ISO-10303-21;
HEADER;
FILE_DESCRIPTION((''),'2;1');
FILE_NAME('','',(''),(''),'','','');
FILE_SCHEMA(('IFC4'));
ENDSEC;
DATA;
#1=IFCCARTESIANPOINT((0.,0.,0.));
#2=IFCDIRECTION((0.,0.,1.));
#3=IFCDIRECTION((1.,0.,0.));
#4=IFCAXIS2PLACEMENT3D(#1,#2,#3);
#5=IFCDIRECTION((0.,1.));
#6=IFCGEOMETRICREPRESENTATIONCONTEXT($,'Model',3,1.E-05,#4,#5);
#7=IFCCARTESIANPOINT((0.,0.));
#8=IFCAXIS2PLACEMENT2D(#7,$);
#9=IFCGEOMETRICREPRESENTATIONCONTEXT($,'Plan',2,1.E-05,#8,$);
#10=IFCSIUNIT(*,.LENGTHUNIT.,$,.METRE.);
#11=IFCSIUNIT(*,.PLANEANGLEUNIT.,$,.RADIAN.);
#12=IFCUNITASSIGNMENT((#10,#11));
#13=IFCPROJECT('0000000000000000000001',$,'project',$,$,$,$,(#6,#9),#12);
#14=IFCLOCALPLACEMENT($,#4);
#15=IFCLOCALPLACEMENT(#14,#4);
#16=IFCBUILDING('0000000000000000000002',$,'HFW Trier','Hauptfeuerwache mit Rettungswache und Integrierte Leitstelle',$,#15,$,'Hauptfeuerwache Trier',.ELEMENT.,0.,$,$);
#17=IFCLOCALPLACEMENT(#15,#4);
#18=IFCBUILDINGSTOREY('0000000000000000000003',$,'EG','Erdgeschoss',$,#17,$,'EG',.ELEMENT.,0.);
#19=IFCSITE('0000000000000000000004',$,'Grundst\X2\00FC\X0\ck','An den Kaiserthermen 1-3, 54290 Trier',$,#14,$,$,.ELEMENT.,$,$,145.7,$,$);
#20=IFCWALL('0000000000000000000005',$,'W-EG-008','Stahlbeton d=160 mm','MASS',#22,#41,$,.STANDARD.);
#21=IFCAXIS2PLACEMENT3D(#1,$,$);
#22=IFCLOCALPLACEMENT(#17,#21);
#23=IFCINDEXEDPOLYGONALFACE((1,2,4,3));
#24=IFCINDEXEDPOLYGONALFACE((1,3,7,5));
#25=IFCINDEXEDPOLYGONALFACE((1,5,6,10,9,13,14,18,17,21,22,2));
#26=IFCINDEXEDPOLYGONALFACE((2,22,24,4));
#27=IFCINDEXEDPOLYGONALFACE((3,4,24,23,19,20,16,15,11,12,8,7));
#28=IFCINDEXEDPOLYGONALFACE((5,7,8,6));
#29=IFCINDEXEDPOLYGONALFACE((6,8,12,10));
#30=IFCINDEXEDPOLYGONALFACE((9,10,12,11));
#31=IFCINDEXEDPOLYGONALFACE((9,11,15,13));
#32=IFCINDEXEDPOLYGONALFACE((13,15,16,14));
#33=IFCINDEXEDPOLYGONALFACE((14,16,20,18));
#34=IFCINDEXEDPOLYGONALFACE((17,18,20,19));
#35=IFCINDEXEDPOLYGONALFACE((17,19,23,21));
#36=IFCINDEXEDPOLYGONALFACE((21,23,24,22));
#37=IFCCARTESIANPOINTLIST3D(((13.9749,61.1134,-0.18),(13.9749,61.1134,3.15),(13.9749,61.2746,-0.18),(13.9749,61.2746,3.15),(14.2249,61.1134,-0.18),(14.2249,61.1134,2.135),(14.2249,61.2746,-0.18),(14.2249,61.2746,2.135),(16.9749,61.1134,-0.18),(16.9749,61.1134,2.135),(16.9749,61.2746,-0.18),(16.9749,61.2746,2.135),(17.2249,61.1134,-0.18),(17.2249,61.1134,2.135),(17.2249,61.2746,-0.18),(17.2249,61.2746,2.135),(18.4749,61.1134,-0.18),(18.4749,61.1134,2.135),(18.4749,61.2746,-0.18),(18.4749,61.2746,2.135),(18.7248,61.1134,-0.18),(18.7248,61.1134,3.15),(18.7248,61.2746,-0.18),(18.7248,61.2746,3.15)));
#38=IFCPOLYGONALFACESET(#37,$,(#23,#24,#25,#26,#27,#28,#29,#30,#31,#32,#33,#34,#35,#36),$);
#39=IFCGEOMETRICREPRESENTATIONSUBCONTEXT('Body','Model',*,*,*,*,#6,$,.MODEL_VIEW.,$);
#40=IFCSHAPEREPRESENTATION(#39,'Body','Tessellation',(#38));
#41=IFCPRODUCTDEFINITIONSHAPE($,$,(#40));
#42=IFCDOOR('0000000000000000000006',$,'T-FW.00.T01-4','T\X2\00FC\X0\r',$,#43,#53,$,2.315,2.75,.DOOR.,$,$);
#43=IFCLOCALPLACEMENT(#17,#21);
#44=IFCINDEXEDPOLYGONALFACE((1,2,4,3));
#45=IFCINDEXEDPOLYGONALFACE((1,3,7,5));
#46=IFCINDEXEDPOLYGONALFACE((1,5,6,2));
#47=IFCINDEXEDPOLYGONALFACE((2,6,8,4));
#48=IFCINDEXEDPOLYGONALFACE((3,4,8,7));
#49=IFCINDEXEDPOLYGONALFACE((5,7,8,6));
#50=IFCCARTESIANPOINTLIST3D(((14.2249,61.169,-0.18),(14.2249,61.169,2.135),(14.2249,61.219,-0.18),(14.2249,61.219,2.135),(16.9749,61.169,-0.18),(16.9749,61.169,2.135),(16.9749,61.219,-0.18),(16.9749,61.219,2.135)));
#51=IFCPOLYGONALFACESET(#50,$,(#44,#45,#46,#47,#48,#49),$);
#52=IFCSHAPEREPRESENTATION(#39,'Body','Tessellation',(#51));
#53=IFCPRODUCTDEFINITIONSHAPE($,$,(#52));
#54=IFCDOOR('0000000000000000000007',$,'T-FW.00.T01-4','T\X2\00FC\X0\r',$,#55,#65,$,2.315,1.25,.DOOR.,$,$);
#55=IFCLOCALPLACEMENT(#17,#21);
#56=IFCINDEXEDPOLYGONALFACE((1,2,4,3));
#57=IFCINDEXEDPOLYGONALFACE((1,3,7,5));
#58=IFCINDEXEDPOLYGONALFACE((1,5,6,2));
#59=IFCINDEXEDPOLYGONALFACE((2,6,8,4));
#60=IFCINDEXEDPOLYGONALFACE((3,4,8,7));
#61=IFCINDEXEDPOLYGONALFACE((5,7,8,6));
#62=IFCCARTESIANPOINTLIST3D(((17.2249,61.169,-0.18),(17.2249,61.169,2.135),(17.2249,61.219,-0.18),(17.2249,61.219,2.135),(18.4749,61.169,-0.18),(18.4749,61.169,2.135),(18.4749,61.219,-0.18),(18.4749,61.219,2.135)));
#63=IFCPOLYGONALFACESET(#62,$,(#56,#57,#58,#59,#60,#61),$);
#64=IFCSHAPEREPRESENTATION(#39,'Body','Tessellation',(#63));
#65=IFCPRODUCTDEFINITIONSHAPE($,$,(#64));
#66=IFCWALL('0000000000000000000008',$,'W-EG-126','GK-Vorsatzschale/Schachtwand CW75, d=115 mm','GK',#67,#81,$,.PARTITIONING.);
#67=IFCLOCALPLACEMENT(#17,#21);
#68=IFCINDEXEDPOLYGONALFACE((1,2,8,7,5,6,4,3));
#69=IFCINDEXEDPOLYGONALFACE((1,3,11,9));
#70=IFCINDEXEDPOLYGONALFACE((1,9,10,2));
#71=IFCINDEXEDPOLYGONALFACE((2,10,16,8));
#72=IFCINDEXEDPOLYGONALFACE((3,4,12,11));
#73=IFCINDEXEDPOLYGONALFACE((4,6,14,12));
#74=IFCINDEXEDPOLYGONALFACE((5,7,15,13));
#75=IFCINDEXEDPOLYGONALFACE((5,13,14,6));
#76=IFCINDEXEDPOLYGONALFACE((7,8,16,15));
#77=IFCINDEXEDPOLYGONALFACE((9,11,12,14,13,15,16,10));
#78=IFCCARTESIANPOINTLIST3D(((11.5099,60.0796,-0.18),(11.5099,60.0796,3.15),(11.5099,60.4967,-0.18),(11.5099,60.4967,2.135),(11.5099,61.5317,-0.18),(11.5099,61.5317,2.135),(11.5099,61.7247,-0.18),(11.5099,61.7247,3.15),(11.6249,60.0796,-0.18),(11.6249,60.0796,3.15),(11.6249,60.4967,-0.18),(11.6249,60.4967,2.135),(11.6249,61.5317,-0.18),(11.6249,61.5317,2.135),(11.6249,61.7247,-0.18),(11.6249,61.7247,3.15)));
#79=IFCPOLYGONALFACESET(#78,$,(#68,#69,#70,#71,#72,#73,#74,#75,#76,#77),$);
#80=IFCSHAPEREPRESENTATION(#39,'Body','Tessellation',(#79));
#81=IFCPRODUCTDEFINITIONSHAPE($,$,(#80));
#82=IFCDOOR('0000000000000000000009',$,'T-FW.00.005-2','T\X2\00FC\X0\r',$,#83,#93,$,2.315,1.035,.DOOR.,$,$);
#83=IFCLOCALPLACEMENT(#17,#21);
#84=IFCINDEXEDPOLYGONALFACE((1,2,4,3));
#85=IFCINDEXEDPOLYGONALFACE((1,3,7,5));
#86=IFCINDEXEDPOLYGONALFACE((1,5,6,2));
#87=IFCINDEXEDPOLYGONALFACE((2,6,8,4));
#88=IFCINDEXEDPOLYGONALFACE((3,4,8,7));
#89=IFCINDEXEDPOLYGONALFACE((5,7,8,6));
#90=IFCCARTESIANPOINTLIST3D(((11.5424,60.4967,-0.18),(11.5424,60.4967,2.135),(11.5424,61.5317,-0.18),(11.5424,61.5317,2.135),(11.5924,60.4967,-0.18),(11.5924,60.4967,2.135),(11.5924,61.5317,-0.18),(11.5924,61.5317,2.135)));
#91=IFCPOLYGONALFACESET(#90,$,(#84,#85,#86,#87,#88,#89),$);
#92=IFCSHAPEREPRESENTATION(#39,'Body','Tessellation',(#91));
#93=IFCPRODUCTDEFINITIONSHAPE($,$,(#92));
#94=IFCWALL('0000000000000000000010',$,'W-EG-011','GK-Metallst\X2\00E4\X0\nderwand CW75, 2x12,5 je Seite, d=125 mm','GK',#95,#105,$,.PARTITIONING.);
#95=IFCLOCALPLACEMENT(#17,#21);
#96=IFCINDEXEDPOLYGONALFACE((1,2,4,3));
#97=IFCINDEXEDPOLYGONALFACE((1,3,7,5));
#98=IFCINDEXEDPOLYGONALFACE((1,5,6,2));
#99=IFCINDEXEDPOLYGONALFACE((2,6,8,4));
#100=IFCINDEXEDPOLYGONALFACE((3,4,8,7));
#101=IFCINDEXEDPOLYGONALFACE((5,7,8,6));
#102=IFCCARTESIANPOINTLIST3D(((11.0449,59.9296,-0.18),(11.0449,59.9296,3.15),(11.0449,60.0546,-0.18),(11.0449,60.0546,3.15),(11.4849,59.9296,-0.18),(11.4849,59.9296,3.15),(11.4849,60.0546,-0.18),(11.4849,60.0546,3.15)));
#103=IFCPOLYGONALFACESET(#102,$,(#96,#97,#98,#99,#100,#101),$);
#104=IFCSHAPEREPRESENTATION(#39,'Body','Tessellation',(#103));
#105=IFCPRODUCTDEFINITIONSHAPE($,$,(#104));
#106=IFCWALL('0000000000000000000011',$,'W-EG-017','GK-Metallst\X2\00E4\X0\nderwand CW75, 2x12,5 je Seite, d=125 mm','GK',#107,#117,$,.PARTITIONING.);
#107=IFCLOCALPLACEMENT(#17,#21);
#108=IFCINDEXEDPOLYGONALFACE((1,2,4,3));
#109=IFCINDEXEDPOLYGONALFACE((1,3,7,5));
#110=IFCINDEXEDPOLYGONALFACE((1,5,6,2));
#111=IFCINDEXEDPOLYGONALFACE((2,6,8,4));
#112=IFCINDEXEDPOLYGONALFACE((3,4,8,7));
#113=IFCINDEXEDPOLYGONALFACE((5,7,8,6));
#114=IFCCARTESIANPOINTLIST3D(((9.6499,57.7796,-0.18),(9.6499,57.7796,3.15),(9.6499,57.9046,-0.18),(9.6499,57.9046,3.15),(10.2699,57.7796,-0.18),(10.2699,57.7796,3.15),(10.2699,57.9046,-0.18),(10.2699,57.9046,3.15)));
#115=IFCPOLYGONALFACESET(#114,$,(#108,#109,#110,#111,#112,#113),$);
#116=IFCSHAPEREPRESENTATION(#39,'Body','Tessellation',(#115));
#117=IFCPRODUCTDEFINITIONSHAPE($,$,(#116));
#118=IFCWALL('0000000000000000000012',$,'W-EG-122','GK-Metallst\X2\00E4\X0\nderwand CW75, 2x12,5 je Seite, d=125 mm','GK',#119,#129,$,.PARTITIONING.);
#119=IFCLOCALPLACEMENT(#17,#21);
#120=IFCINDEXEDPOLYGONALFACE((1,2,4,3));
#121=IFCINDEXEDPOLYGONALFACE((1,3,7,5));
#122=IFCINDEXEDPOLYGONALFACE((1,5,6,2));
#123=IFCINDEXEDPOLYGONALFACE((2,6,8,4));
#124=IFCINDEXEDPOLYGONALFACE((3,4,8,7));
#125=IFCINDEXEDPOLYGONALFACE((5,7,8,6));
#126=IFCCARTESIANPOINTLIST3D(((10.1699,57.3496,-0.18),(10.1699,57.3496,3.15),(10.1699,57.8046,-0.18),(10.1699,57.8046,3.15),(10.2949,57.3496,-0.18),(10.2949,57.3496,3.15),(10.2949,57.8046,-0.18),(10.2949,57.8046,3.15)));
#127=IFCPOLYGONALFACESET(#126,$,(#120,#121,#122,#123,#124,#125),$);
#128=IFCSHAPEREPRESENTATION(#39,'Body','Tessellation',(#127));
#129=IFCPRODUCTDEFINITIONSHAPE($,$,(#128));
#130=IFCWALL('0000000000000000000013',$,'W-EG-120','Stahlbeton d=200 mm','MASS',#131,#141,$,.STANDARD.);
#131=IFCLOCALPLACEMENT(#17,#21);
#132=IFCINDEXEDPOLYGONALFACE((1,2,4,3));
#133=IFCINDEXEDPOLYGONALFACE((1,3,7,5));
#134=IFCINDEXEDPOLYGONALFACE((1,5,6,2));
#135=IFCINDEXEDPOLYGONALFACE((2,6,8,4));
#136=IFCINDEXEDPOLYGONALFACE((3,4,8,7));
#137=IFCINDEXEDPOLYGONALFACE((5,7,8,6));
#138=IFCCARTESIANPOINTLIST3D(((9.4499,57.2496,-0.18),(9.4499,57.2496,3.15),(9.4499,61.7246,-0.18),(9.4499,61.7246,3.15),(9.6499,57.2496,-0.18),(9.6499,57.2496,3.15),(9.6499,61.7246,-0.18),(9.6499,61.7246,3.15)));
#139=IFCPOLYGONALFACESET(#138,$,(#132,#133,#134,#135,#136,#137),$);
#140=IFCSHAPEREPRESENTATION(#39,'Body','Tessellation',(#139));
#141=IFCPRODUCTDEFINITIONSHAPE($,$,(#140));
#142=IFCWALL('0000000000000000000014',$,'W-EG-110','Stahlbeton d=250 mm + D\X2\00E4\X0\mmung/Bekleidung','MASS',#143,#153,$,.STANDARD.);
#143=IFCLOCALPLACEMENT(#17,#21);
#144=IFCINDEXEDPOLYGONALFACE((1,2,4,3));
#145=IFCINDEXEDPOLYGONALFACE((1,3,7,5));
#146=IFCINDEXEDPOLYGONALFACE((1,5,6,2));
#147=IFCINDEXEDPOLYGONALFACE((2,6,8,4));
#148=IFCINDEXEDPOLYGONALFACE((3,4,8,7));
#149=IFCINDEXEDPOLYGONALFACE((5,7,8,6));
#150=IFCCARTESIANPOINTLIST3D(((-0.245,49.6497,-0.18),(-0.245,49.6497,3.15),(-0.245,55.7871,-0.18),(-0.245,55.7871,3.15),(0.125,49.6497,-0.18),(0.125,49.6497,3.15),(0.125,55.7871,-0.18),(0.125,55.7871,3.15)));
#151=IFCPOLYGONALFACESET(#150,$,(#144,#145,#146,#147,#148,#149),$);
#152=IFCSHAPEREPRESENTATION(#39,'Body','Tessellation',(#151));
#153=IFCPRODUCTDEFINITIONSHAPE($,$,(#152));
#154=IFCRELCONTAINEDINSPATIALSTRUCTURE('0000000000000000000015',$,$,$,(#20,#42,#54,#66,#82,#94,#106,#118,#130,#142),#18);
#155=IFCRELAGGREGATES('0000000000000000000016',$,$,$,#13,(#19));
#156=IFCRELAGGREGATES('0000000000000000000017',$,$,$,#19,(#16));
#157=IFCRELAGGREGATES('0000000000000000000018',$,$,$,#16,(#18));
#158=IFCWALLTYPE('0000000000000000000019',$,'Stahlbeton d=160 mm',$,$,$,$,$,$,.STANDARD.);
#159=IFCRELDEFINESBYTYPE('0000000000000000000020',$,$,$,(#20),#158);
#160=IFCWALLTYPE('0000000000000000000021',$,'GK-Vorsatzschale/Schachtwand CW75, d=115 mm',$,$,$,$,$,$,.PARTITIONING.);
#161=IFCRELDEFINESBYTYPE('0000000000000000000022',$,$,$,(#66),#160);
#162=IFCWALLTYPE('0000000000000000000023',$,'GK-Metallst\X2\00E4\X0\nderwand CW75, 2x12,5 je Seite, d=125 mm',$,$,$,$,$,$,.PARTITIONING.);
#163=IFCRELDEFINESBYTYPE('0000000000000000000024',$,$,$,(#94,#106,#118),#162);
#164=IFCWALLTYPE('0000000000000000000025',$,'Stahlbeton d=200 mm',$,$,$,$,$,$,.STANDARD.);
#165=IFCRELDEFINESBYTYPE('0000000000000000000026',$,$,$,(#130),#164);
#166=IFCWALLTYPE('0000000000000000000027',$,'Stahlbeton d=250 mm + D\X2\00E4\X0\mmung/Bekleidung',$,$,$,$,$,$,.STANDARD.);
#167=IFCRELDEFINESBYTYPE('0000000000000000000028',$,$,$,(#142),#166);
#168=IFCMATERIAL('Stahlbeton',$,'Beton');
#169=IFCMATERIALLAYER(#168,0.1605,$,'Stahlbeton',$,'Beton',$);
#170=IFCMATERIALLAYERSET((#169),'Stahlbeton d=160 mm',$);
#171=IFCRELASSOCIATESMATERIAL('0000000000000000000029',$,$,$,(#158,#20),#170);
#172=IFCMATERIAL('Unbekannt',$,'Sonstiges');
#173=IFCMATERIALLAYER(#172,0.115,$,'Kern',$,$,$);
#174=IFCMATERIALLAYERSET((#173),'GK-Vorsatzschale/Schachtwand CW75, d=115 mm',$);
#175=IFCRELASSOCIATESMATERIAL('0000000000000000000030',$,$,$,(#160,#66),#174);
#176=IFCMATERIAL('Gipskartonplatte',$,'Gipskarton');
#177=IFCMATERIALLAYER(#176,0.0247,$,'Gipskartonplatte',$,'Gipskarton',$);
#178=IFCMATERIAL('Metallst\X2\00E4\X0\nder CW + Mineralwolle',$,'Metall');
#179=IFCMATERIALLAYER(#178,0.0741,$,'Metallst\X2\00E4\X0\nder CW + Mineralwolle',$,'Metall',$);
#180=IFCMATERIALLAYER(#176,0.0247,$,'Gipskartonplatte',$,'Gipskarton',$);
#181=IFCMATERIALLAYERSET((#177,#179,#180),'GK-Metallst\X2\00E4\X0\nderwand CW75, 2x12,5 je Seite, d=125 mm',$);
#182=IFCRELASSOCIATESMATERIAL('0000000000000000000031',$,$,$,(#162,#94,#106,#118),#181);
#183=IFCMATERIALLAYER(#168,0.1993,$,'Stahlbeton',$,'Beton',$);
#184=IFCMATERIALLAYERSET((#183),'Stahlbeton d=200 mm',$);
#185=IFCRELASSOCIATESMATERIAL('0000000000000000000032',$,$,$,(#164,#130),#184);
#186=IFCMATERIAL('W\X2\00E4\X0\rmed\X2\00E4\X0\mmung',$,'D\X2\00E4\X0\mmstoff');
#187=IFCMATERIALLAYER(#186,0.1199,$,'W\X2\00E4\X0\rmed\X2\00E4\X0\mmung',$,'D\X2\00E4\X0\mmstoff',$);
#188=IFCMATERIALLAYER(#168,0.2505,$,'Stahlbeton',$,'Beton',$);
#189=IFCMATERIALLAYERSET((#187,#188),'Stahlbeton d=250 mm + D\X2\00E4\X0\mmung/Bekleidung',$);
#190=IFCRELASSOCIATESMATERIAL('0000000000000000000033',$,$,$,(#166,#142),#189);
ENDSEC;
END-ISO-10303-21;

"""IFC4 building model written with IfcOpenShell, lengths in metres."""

from ifc_helpers import new_model, si_unit, direction, frame, frame_2d, origin_with_axes, origin_2d, place, context, subcontext, project, spatial, rectangle, extrude, material, layer, layer_set, layer_usage, type_object, element, fill, save


model = new_model("IFC4")

# Units and contexts
model_context = context("Model", 3, precision=1e-05, world=origin_with_axes(), true_north=direction((0.0, 1.0)))
plan_context = context("Plan", 2, precision=1e-05, world=origin_2d())
body_context = subcontext(model_context, "Body", "Model", "MODEL_VIEW")
ifc_project = project(units=[si_unit("LENGTHUNIT", "METRE"), si_unit("PLANEANGLEUNIT", "RADIAN")], contexts=[model_context, plan_context])

# Site, building, storey
site_placement = place(None, origin_with_axes())
site = spatial("IfcSite", under=ifc_project, at=site_placement, Name="Grundstück", Description="An den Kaiserthermen 1-3, 54290 Trier", CompositionType="ELEMENT", RefElevation=145.7)
building_placement = place(site_placement, origin_with_axes())
building = spatial("IfcBuilding", under=site, at=building_placement, Name="HFW Trier", Description="Hauptfeuerwache mit Rettungswache und Integrierte Leitstelle", LongName="Hauptfeuerwache Trier", CompositionType="ELEMENT", ElevationOfRefHeight=0.0)
storey_placement = place(building_placement, origin_with_axes())
storey = spatial("IfcBuildingStorey", under=building, at=storey_placement, Name="EG", Description="Erdgeschoss", LongName="EG", CompositionType="ELEMENT", Elevation=0.0)

# Shared definitions
ifc_material_1 = material(Name="Stahlbeton", Category="Beton")

# Shared definitions
ifc_material_2 = material(Name="Gipskartonplatte", Category="Gipskarton")
ifc_material_3 = material(Name="Metallständer CW + Mineralwolle", Category="Metall")

# Wall, openings, doors
ifc_layer_1 = layer(ifc_material_1, 0.1605, Name="Stahlbeton", Category="Beton")
ifc_layer_set_1 = layer_set([ifc_layer_1], Name="Stahlbeton d=160 mm")
ifc_layer_usage_1 = layer_usage(ifc_layer_set_1, "AXIS2", "POSITIVE", -0.0805)
wall_type_1 = type_object("IfcWallType", Name="Stahlbeton d=160 mm", PredefinedType="STANDARD", material=ifc_layer_set_1)
wall_1_placement = place(storey_placement, frame((13.9749, 61.194, -0.18), z_axis=(0.0, 0.0, 1.0), x_axis=(1.0, 0.0, 0.0)))
wall_1 = element("IfcWall", 1, at=wall_1_placement, inside=storey, type_object=wall_type_1, material=ifc_layer_usage_1, Name="W-EG-008", Description="Stahlbeton d=160 mm", ObjectType="MASS", PredefinedType="STANDARD", context=body_context, shape_type="SweptSolid", body=[
    extrude(rectangle(XDim=4.7499, YDim=0.1611, at=frame_2d((2.3749, 0.0))), origin_with_axes(), (0.0, 0.0, 1.0), 3.33),
])
opening_1_placement = place(wall_1_placement, frame((0.25, 0.0, 0.0), z_axis=(0.0, 0.0, 1.0), x_axis=(1.0, 0.0, 0.0)))
opening_1 = element("IfcOpeningElement", 2, at=opening_1_placement, cuts=wall_1, PredefinedType="OPENING", context=body_context, shape_type="SweptSolid", body=[
    extrude(rectangle(XDim=2.75, YDim=0.2611, at=frame_2d((1.375, 0.0))), origin_with_axes(), (0.0, 0.0, 1.0), 2.315),
])
opening_2_placement = place(wall_1_placement, frame((3.25, 0.0, 0.0), z_axis=(0.0, 0.0, 1.0), x_axis=(1.0, 0.0, 0.0)))
opening_2 = element("IfcOpeningElement", 3, at=opening_2_placement, cuts=wall_1, PredefinedType="OPENING", context=body_context, shape_type="SweptSolid", body=[
    extrude(rectangle(XDim=1.25, YDim=0.2611, at=frame_2d((0.625, 0.0))), origin_with_axes(), (0.0, 0.0, 1.0), 2.315),
])
door_1_placement = place(wall_1_placement, frame((0.25, 0.0, 0.0), z_axis=(0.0, 0.0, 1.0), x_axis=(1.0, 0.0, 0.0)))
door_1 = element("IfcDoor", 4, at=door_1_placement, inside=storey, Name="T-FW.00.T01-4", Description="Tür", OverallHeight=2.315, OverallWidth=2.75, PredefinedType="DOOR", context=body_context, shape_type="SweptSolid", body=[
    extrude(rectangle(XDim=2.75, YDim=0.05, at=frame_2d((1.375, 0.0))), origin_with_axes(), (0.0, 0.0, 1.0), 2.315),
])
fill(opening_1, door_1)
door_2_placement = place(wall_1_placement, frame((3.25, 0.0, 0.0), z_axis=(0.0, 0.0, 1.0), x_axis=(1.0, 0.0, 0.0)))
door_2 = element("IfcDoor", 5, at=door_2_placement, inside=storey, Name="T-FW.00.T01-4", Description="Tür", OverallHeight=2.315, OverallWidth=1.25, PredefinedType="DOOR", context=body_context, shape_type="SweptSolid", body=[
    extrude(rectangle(XDim=1.25, YDim=0.05, at=frame_2d((0.625, 0.0))), origin_with_axes(), (0.0, 0.0, 1.0), 2.315),
])
fill(opening_2, door_2)

# Wall, opening, door
ifc_material_4 = material(Name="Unbekannt", Category="Sonstiges")
ifc_layer_2 = layer(ifc_material_4, 0.115, Name="Kern")
ifc_layer_set_2 = layer_set([ifc_layer_2], Name="GK-Vorsatzschale/Schachtwand CW75, d=115 mm")
ifc_layer_usage_2 = layer_usage(ifc_layer_set_2, "AXIS2", "POSITIVE", -0.0575)
wall_type_2 = type_object("IfcWallType", Name="GK-Vorsatzschale/Schachtwand CW75, d=115 mm", PredefinedType="PARTITIONING", material=ifc_layer_set_2)
wall_2_placement = place(storey_placement, frame((11.5674, 61.7247, -0.18), z_axis=(0.0, 0.0, 1.0), x_axis=(0.0, -1.0, 0.0)))
wall_2 = element("IfcWall", 6, at=wall_2_placement, inside=storey, type_object=wall_type_2, material=ifc_layer_usage_2, Name="W-EG-126", Description="GK-Vorsatzschale/Schachtwand CW75, d=115 mm", ObjectType="GK", PredefinedType="PARTITIONING", context=body_context, shape_type="SweptSolid", body=[
    extrude(rectangle(XDim=1.6451, YDim=0.115, at=frame_2d((0.8225, 0.0))), origin_with_axes(), (0.0, 0.0, 1.0), 3.33),
])
opening_3_placement = place(wall_2_placement, frame((0.193, 0.0, 0.0), z_axis=(0.0, 0.0, 1.0), x_axis=(1.0, 0.0, 0.0)))
opening_3 = element("IfcOpeningElement", 7, at=opening_3_placement, cuts=wall_2, PredefinedType="OPENING", context=body_context, shape_type="SweptSolid", body=[
    extrude(rectangle(XDim=1.035, YDim=0.215, at=frame_2d((0.5175, 0.0))), origin_with_axes(), (0.0, 0.0, 1.0), 2.315),
])
door_3_placement = place(wall_2_placement, frame((0.193, 0.0, 0.0), z_axis=(0.0, 0.0, 1.0), x_axis=(1.0, 0.0, 0.0)))
door_3 = element("IfcDoor", 8, at=door_3_placement, inside=storey, Name="T-FW.00.005-2", Description="Tür", OverallHeight=2.315, OverallWidth=1.035, PredefinedType="DOOR", context=body_context, shape_type="SweptSolid", body=[
    extrude(rectangle(XDim=1.035, YDim=0.05, at=frame_2d((0.5175, 0.0))), origin_with_axes(), (0.0, 0.0, 1.0), 2.315),
])
fill(opening_3, door_3)

# Walls
ifc_layer_3 = layer(ifc_material_2, 0.0247, Name="Gipskartonplatte", Category="Gipskarton")
ifc_layer_4 = layer(ifc_material_3, 0.0741, Name="Metallständer CW + Mineralwolle", Category="Metall")
ifc_layer_5 = layer(ifc_material_2, 0.0247, Name="Gipskartonplatte", Category="Gipskarton")
ifc_layer_set_3 = layer_set([ifc_layer_3, ifc_layer_4, ifc_layer_5], Name="GK-Metallständerwand CW75, 2x12,5 je Seite, d=125 mm")
ifc_layer_usage_3 = layer_usage(ifc_layer_set_3, "AXIS2", "POSITIVE", -0.0625)
wall_type_3 = type_object("IfcWallType", Name="GK-Metallständerwand CW75, 2x12,5 je Seite, d=125 mm", PredefinedType="PARTITIONING", material=ifc_layer_set_3)
wall_3_placement = place(storey_placement, frame((11.0449, 59.9921, -0.18), z_axis=(0.0, 0.0, 1.0), x_axis=(1.0, 0.0, 0.0)))
element("IfcWall", 9, at=wall_3_placement, inside=storey, type_object=wall_type_3, material=ifc_layer_usage_3, Name="W-EG-011", Description="GK-Metallständerwand CW75, 2x12,5 je Seite, d=125 mm", ObjectType="GK", PredefinedType="PARTITIONING", context=body_context, shape_type="SweptSolid", body=[
    extrude(rectangle(XDim=0.44, YDim=0.125, at=frame_2d((0.22, 0.0))), origin_with_axes(), (0.0, 0.0, 1.0), 3.33),
])
ifc_layer_usage_4 = layer_usage(ifc_layer_set_3, "AXIS2", "POSITIVE", -0.0625)
wall_4_placement = place(storey_placement, frame((9.6499, 57.8421, -0.18), z_axis=(0.0, 0.0, 1.0), x_axis=(1.0, 0.0, 0.0)))
element("IfcWall", 10, at=wall_4_placement, inside=storey, type_object=wall_type_3, material=ifc_layer_usage_4, Name="W-EG-017", Description="GK-Metallständerwand CW75, 2x12,5 je Seite, d=125 mm", ObjectType="GK", PredefinedType="PARTITIONING", context=body_context, shape_type="SweptSolid", body=[
    extrude(rectangle(XDim=0.62, YDim=0.125, at=frame_2d((0.31, 0.0))), origin_with_axes(), (0.0, 0.0, 1.0), 3.33),
])
ifc_layer_usage_5 = layer_usage(ifc_layer_set_3, "AXIS2", "POSITIVE", -0.0625)
wall_5_placement = place(storey_placement, frame((10.2324, 57.8046, -0.18), z_axis=(0.0, 0.0, 1.0), x_axis=(0.0, -1.0, 0.0)))
element("IfcWall", 11, at=wall_5_placement, inside=storey, type_object=wall_type_3, material=ifc_layer_usage_5, Name="W-EG-122", Description="GK-Metallständerwand CW75, 2x12,5 je Seite, d=125 mm", ObjectType="GK", PredefinedType="PARTITIONING", context=body_context, shape_type="SweptSolid", body=[
    extrude(rectangle(XDim=0.455, YDim=0.125, at=frame_2d((0.2275, 0.0))), origin_with_axes(), (0.0, 0.0, 1.0), 3.33),
])
ifc_layer_6 = layer(ifc_material_1, 0.1993, Name="Stahlbeton", Category="Beton")
ifc_layer_set_4 = layer_set([ifc_layer_6], Name="Stahlbeton d=200 mm")
ifc_layer_usage_6 = layer_usage(ifc_layer_set_4, "AXIS2", "POSITIVE", -0.1)
wall_type_4 = type_object("IfcWallType", Name="Stahlbeton d=200 mm", PredefinedType="STANDARD", material=ifc_layer_set_4)
wall_6_placement = place(storey_placement, frame((9.5499, 61.7246, -0.18), z_axis=(0.0, 0.0, 1.0), x_axis=(0.0, -1.0, 0.0)))
element("IfcWall", 12, at=wall_6_placement, inside=storey, type_object=wall_type_4, material=ifc_layer_usage_6, Name="W-EG-120", Description="Stahlbeton d=200 mm", ObjectType="MASS", PredefinedType="STANDARD", context=body_context, shape_type="SweptSolid", body=[
    extrude(rectangle(XDim=4.475, YDim=0.2, at=frame_2d((2.2375, 0.0))), origin_with_axes(), (0.0, 0.0, 1.0), 3.33),
])
ifc_material_5 = material(Name="Wärmedämmung", Category="Dämmstoff")
ifc_layer_7 = layer(ifc_material_5, 0.1199, Name="Wärmedämmung", Category="Dämmstoff")
ifc_layer_8 = layer(ifc_material_1, 0.2505, Name="Stahlbeton", Category="Beton")
ifc_layer_set_5 = layer_set([ifc_layer_7, ifc_layer_8], Name="Stahlbeton d=250 mm + Dämmung/Bekleidung")
ifc_layer_usage_7 = layer_usage(ifc_layer_set_5, "AXIS2", "POSITIVE", -0.185)
wall_type_5 = type_object("IfcWallType", Name="Stahlbeton d=250 mm + Dämmung/Bekleidung", PredefinedType="STANDARD", material=ifc_layer_set_5)
wall_7_placement = place(storey_placement, frame((-0.06, 55.7871, -0.18), z_axis=(0.0, 0.0, 1.0), x_axis=(0.0, -1.0, 0.0)))
element("IfcWall", 13, at=wall_7_placement, inside=storey, type_object=wall_type_5, material=ifc_layer_usage_7, Name="W-EG-110", Description="Stahlbeton d=250 mm + Dämmung/Bekleidung", ObjectType="MASS", PredefinedType="STANDARD", context=body_context, shape_type="SweptSolid", body=[
    extrude(rectangle(XDim=6.1374, YDim=0.37, at=frame_2d((3.0687, 0.0))), origin_with_axes(), (0.0, 0.0, 1.0), 3.33),
])

save(model, "model.ifc")
